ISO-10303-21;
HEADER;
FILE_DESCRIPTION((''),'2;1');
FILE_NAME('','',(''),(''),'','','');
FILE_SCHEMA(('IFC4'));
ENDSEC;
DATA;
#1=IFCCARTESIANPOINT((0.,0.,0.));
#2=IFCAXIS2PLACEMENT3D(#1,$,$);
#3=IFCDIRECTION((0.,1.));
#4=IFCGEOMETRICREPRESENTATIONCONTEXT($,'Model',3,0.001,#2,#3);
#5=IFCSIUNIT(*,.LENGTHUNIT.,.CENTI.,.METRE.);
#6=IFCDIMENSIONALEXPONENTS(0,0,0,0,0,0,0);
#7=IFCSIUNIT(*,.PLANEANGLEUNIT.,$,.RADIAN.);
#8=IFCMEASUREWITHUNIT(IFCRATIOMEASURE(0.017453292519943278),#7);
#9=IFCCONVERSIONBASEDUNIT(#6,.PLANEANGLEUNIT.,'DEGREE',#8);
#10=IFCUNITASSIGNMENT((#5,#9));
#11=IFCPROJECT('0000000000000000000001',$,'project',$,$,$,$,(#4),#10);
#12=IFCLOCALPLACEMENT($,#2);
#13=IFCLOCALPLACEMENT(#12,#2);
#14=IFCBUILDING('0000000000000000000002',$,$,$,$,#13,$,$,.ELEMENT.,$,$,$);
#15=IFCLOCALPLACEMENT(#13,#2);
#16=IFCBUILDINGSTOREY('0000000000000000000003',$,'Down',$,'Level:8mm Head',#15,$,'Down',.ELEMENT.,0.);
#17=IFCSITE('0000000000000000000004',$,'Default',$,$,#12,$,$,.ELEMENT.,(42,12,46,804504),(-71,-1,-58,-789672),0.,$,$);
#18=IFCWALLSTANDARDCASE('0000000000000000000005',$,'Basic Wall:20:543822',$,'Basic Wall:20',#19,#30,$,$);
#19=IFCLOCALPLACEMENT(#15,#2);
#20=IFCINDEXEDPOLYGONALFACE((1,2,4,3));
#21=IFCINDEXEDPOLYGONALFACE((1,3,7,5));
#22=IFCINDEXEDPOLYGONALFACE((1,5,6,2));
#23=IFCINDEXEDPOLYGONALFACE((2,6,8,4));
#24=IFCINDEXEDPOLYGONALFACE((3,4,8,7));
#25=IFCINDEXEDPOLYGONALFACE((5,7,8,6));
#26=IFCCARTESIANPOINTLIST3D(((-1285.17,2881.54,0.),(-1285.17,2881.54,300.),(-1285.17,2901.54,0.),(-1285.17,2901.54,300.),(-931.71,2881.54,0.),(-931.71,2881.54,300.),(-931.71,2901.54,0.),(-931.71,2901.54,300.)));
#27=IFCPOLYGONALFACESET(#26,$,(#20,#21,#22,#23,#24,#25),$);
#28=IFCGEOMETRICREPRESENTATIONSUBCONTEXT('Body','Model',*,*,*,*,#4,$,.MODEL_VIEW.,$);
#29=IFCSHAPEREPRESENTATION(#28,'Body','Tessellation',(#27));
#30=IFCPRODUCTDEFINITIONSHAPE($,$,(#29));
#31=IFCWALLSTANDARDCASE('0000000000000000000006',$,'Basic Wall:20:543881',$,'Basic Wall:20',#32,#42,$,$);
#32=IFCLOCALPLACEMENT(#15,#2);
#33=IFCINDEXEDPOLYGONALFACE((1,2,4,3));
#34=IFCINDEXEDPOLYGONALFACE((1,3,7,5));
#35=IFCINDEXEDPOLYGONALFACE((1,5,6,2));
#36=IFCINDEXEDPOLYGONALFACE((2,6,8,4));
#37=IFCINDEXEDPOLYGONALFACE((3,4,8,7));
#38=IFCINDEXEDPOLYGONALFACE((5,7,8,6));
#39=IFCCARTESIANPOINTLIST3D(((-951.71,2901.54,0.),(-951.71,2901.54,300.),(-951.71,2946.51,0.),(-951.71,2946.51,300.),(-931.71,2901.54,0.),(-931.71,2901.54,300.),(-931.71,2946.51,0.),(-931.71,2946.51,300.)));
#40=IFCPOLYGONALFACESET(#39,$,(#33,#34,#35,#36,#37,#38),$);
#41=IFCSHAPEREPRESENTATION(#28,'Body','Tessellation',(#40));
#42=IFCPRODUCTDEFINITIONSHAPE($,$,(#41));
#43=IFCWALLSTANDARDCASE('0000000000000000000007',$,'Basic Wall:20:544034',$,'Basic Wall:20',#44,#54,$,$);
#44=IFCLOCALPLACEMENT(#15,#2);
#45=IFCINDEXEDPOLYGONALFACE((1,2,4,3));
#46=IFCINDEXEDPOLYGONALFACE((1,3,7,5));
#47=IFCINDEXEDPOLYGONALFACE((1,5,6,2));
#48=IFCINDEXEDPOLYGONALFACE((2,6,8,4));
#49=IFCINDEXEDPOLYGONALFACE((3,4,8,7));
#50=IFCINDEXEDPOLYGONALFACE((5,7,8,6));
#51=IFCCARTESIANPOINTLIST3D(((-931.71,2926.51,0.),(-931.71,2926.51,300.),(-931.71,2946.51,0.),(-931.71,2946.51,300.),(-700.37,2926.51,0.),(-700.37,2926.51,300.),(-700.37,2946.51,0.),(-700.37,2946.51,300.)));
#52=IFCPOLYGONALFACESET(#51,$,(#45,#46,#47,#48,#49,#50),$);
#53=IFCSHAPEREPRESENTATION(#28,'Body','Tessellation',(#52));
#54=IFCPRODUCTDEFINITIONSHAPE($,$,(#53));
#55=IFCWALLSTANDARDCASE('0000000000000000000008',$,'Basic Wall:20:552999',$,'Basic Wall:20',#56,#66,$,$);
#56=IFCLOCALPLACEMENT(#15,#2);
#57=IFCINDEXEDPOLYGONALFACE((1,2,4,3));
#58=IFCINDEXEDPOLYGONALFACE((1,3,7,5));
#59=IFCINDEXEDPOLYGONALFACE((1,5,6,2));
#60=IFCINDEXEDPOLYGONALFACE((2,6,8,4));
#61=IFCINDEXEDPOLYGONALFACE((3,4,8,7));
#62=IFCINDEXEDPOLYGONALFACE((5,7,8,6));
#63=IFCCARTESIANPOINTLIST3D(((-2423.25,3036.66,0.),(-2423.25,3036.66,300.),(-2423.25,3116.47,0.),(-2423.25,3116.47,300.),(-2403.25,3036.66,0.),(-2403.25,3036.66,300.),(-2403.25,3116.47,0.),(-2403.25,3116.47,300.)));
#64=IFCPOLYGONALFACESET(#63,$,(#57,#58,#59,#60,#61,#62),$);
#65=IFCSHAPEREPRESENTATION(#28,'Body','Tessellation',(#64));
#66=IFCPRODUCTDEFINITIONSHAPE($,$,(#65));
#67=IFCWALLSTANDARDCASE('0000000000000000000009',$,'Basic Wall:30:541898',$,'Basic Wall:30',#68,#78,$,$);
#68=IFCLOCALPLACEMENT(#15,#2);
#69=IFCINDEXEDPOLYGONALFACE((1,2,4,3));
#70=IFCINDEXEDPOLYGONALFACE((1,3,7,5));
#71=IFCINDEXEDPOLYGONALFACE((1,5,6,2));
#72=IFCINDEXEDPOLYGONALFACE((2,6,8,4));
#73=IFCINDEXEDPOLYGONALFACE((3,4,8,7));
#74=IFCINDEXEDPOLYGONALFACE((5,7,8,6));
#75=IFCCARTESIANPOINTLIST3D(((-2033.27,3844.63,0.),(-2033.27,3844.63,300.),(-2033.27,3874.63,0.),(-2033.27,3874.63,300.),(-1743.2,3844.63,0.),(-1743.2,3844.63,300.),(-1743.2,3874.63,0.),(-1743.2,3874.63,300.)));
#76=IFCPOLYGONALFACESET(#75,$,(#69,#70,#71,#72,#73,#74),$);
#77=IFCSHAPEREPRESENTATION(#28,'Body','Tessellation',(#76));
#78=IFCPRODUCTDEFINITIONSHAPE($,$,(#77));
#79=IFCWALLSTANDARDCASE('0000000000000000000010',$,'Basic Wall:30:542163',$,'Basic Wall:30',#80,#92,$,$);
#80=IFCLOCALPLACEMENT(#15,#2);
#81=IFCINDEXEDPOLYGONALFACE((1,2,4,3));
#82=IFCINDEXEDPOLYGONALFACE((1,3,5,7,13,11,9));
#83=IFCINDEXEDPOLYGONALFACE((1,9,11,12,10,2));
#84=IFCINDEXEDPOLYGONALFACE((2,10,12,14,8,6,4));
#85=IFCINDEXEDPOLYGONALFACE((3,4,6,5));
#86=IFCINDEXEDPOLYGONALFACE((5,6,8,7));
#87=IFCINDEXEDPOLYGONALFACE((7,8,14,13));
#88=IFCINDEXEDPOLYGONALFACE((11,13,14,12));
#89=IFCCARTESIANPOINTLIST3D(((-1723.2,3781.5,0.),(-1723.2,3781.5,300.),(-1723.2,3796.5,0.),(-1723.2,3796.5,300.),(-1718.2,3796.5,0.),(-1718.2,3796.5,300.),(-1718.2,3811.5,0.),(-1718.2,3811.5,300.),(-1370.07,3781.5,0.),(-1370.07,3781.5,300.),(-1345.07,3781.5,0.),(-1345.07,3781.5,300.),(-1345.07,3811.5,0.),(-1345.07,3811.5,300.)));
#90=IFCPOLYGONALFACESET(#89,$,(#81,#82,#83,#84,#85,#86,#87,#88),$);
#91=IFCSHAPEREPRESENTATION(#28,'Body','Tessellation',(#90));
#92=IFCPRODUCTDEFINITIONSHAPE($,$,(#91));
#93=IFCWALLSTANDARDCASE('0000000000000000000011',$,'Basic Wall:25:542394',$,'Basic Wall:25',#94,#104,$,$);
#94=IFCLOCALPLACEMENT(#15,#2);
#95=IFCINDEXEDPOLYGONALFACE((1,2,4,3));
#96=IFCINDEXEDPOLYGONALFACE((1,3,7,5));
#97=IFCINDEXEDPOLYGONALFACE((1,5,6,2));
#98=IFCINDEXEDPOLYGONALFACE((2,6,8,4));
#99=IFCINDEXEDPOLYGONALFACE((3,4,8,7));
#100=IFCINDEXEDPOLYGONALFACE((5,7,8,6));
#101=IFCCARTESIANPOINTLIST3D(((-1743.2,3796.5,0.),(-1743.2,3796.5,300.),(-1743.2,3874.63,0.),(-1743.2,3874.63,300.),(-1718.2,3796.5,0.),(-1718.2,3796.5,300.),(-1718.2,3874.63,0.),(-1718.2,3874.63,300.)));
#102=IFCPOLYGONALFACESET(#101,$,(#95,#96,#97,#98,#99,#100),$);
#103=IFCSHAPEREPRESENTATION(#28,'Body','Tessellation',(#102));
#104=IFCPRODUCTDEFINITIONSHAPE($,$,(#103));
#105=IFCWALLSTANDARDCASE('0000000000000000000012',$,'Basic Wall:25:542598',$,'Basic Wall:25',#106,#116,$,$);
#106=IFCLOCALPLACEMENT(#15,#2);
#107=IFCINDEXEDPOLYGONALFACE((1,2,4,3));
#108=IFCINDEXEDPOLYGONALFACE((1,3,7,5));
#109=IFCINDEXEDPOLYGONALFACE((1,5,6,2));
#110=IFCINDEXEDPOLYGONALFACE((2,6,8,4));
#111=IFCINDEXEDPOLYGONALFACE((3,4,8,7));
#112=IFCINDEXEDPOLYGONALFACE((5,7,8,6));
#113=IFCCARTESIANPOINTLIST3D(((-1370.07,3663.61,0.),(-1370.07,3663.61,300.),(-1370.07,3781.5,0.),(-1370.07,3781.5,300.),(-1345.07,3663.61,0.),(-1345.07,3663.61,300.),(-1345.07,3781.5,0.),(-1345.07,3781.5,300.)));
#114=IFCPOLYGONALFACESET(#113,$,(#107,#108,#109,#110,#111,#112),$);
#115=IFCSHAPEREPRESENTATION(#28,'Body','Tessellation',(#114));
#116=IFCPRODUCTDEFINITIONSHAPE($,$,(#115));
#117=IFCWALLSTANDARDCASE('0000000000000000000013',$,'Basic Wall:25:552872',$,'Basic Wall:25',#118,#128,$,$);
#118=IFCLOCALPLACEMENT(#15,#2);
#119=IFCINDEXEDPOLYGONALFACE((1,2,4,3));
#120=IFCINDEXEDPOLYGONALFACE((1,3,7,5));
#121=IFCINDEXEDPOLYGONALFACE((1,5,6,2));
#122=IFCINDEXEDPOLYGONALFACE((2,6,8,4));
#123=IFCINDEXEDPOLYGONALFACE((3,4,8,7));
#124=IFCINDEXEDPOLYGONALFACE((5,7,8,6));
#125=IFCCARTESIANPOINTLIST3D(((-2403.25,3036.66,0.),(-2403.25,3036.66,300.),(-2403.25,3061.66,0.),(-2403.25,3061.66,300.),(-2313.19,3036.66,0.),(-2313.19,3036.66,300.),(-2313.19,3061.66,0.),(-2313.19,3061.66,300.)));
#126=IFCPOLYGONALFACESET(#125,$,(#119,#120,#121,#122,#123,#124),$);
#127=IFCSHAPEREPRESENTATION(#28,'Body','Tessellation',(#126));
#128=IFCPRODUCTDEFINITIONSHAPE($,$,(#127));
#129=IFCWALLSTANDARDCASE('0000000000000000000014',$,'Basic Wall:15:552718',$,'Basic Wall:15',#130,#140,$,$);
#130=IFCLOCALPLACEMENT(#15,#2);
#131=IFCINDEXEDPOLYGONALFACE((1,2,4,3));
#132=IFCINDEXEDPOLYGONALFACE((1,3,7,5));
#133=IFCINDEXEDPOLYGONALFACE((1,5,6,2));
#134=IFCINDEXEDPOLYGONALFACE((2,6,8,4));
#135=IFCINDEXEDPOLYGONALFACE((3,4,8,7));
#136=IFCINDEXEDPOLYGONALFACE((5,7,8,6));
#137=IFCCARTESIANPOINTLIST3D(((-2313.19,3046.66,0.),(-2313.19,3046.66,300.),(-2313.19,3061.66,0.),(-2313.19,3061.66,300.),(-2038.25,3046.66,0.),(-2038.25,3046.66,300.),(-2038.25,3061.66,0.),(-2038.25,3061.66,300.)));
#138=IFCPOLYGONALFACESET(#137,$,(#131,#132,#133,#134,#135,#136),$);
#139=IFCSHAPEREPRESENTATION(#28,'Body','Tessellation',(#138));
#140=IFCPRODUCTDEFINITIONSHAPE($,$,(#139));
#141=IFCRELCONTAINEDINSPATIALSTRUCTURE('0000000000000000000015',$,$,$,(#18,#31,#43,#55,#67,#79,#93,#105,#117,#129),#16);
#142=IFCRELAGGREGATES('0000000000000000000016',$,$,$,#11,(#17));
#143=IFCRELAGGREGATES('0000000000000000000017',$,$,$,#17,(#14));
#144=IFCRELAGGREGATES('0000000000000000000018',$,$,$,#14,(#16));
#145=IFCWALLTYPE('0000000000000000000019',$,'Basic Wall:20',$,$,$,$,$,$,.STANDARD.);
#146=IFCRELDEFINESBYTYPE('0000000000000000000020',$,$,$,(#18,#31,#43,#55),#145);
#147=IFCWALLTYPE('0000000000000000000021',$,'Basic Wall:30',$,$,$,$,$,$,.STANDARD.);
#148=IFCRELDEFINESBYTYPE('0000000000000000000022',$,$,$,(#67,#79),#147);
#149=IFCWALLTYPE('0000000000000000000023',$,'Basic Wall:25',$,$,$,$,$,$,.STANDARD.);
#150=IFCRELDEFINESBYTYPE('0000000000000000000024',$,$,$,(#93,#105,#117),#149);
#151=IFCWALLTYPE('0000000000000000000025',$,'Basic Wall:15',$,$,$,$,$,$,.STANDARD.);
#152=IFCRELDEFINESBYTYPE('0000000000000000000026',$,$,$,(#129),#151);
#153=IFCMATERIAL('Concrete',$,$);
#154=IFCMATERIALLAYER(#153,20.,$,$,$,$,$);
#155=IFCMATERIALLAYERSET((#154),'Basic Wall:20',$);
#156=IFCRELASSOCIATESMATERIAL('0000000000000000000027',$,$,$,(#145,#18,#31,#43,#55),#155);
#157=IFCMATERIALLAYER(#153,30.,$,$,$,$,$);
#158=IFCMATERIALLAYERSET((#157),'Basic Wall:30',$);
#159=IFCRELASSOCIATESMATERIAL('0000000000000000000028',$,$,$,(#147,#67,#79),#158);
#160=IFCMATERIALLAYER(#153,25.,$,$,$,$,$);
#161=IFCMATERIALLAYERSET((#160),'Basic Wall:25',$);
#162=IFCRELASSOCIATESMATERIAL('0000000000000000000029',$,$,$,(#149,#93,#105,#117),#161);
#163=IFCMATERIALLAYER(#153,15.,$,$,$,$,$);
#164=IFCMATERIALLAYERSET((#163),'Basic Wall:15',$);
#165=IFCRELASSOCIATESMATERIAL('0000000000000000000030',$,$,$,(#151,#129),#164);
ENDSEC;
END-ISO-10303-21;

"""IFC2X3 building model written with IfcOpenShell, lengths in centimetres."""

from ifc_helpers import new_model, entity, si_unit, converted_unit, direction, frame, frame_2d, origin, place, context, subcontext, project, spatial, polyline, rectangle, outline, extrude, material, layer, layer_set, layer_usage, type_object, element, save


model = new_model("IFC2X3")

# Units and contexts
model_context = context("Model", 3, precision=0.001, world=origin(), true_north=direction((0.0, 1.0)))
body_context = subcontext(model_context, "Body", "Model", "MODEL_VIEW")
ifc_project = project(units=[si_unit("LENGTHUNIT", "METRE", prefix="CENTI"), converted_unit("PLANEANGLEUNIT", "DEGREE", entity("IfcRatioMeasure", 0.017453292519943278), si_unit("PLANEANGLEUNIT", "RADIAN"), dimensions=[0, 0, 0, 0, 0, 0, 0])], contexts=[model_context])

# Site, building, storey
site_placement = place(None, origin())
site = spatial("IfcSite", under=ifc_project, at=site_placement, Name="Default", CompositionType="ELEMENT", RefLatitude=(42, 12, 46, 804504), RefLongitude=(-71, -1, -58, -789672), RefElevation=0.0)
building_placement = place(site_placement, origin())
building = spatial("IfcBuilding", under=site, at=building_placement, CompositionType="ELEMENT")
storey_placement = place(building_placement, origin())
storey = spatial("IfcBuildingStorey", under=building, at=storey_placement, Name="Down", ObjectType="Level:8mm Head", LongName="Down", CompositionType="ELEMENT", Elevation=0.0)

# Walls
ifc_material = material(Name="Concrete")
ifc_layer_1 = layer(ifc_material, 20.0)
ifc_layer_set_1 = layer_set([ifc_layer_1], Name="Basic Wall:20")
wall_type_1 = type_object("IfcWallType", Name="Basic Wall:20", PredefinedType="STANDARD", material=ifc_layer_set_1)
ifc_layer_usage_1 = layer_usage(ifc_layer_set_1, "AXIS2", "POSITIVE", -10.0)
wall_1_placement = place(storey_placement, frame((-1285.17, 2891.54, 0.0)))
element("IfcWallStandardCase", 1, at=wall_1_placement, inside=storey, type_object=wall_type_1, material=ifc_layer_usage_1, Name="Basic Wall:20:543822", ObjectType="Basic Wall:20", context=body_context, shape_type="SweptSolid", body=[
    extrude(rectangle(XDim=353.47, YDim=20.0, at=frame_2d((176.73, 0.0), x_axis=(-1.0, 0.0))), origin(), (0.0, 0.0, 1.0), 300.0),
])
ifc_layer_usage_2 = layer_usage(ifc_layer_set_1, "AXIS2", "POSITIVE", -10.0)
wall_2_placement = place(storey_placement, frame((-941.71, 2901.54, 0.0), z_axis=(0.0, 0.0, 1.0), x_axis=(0.0, 1.0, 0.0)))
element("IfcWallStandardCase", 2, at=wall_2_placement, inside=storey, type_object=wall_type_1, material=ifc_layer_usage_2, Name="Basic Wall:20:543881", ObjectType="Basic Wall:20", context=body_context, shape_type="SweptSolid", body=[
    extrude(rectangle(XDim=44.98, YDim=20.0, at=frame_2d((22.49, 0.0), x_axis=(-1.0, 0.0))), origin(), (0.0, 0.0, 1.0), 300.0),
])
ifc_layer_usage_3 = layer_usage(ifc_layer_set_1, "AXIS2", "NEGATIVE", 10.0)
wall_3_placement = place(storey_placement, frame((-931.71, 2936.51, 0.0)))
element("IfcWallStandardCase", 3, at=wall_3_placement, inside=storey, type_object=wall_type_1, material=ifc_layer_usage_3, Name="Basic Wall:20:544034", ObjectType="Basic Wall:20", context=body_context, shape_type="SweptSolid", body=[
    extrude(rectangle(XDim=231.34, YDim=20.0, at=frame_2d((115.67, 0.0), x_axis=(-1.0, 0.0))), origin(), (0.0, 0.0, 1.0), 300.0),
])
ifc_layer_usage_4 = layer_usage(ifc_layer_set_1, "AXIS2", "NEGATIVE", 10.0)
wall_4_placement = place(storey_placement, frame((-2413.25, 3036.66, 0.0), z_axis=(0.0, 0.0, 1.0), x_axis=(0.0, 1.0, 0.0)))
element("IfcWallStandardCase", 4, at=wall_4_placement, inside=storey, type_object=wall_type_1, material=ifc_layer_usage_4, Name="Basic Wall:20:552999", ObjectType="Basic Wall:20", context=body_context, shape_type="SweptSolid", body=[
    extrude(rectangle(XDim=79.82, YDim=20.0, at=frame_2d((39.91, 0.0), x_axis=(-1.0, 0.0))), origin(), (0.0, 0.0, 1.0), 300.0),
])
ifc_layer_2 = layer(ifc_material, 30.0)
ifc_layer_set_2 = layer_set([ifc_layer_2], Name="Basic Wall:30")
ifc_layer_usage_5 = layer_usage(ifc_layer_set_2, "AXIS2", "NEGATIVE", 15.0)
wall_type_2 = type_object("IfcWallType", Name="Basic Wall:30", PredefinedType="STANDARD", material=ifc_layer_set_2)
wall_5_placement = place(storey_placement, frame((-2033.27, 3859.63, 0.0)))
element("IfcWallStandardCase", 5, at=wall_5_placement, inside=storey, type_object=wall_type_2, material=ifc_layer_usage_5, Name="Basic Wall:30:541898", ObjectType="Basic Wall:30", context=body_context, shape_type="SweptSolid", body=[
    extrude(rectangle(XDim=290.07, YDim=30.0, at=frame_2d((145.04, 0.0), x_axis=(-1.0, 0.0))), origin(), (0.0, 0.0, 1.0), 300.0),
])
ifc_layer_usage_6 = layer_usage(ifc_layer_set_2, "AXIS2", "POSITIVE", -15.0)
wall_6_placement = place(storey_placement, frame((-1723.2, 3796.5, 0.0)))
element("IfcWallStandardCase", 6, at=wall_6_placement, inside=storey, type_object=wall_type_2, material=ifc_layer_usage_6, Name="Basic Wall:30:542163", ObjectType="Basic Wall:30", context=body_context, shape_type="SweptSolid", body=[
    extrude(outline(polyline([(378.13, -15.0), (378.13, 15.0), (5.0, 15.0), (5.0, 0.0), (0.0, 0.0), (0.0, -15.0), (353.13, -15.0), (378.13, -15.0)])), origin(), (0.0, 0.0, 1.0), 300.0),
])
ifc_layer_3 = layer(ifc_material, 25.0)
ifc_layer_set_3 = layer_set([ifc_layer_3], Name="Basic Wall:25")
ifc_layer_usage_7 = layer_usage(ifc_layer_set_3, "AXIS2", "NEGATIVE", 12.5)
wall_type_3 = type_object("IfcWallType", Name="Basic Wall:25", PredefinedType="STANDARD", material=ifc_layer_set_3)
wall_7_placement = place(storey_placement, frame((-1730.7, 3874.63, 0.0), z_axis=(0.0, 0.0, 1.0), x_axis=(0.0, -1.0, 0.0)))
element("IfcWallStandardCase", 7, at=wall_7_placement, inside=storey, type_object=wall_type_3, material=ifc_layer_usage_7, Name="Basic Wall:25:542394", ObjectType="Basic Wall:25", context=body_context, shape_type="SweptSolid", body=[
    extrude(rectangle(XDim=78.13, YDim=25.0, at=frame_2d((39.06, 0.0), x_axis=(-1.0, 0.0))), origin(), (0.0, 0.0, 1.0), 300.0),
])
ifc_layer_usage_8 = layer_usage(ifc_layer_set_3, "AXIS2", "NEGATIVE", 12.5)
wall_8_placement = place(storey_placement, frame((-1357.57, 3781.5, 0.0), z_axis=(0.0, 0.0, 1.0), x_axis=(0.0, -1.0, 0.0)))
element("IfcWallStandardCase", 8, at=wall_8_placement, inside=storey, type_object=wall_type_3, material=ifc_layer_usage_8, Name="Basic Wall:25:542598", ObjectType="Basic Wall:25", context=body_context, shape_type="SweptSolid", body=[
    extrude(rectangle(XDim=117.89, YDim=25.0, at=frame_2d((58.95, 0.0), x_axis=(-1.0, 0.0))), origin(), (0.0, 0.0, 1.0), 300.0),
])
ifc_layer_usage_9 = layer_usage(ifc_layer_set_3, "AXIS2", "POSITIVE", -12.5)
wall_9_placement = place(storey_placement, frame((-2313.19, 3049.16, 0.0), z_axis=(0.0, 0.0, 1.0), x_axis=(-1.0, 0.0, 0.0)))
element("IfcWallStandardCase", 9, at=wall_9_placement, inside=storey, type_object=wall_type_3, material=ifc_layer_usage_9, Name="Basic Wall:25:552872", ObjectType="Basic Wall:25", context=body_context, shape_type="SweptSolid", body=[
    extrude(rectangle(XDim=90.06, YDim=25.0, at=frame_2d((45.03, 0.0), x_axis=(-1.0, 0.0))), origin(), (0.0, 0.0, 1.0), 300.0),
])
ifc_layer_4 = layer(ifc_material, 15.0)
ifc_layer_set_4 = layer_set([ifc_layer_4], Name="Basic Wall:15")
ifc_layer_usage_10 = layer_usage(ifc_layer_set_4, "AXIS2", "POSITIVE", -7.5)
wall_type_4 = type_object("IfcWallType", Name="Basic Wall:15", PredefinedType="STANDARD", material=ifc_layer_set_4)
wall_10_placement = place(storey_placement, frame((-2038.25, 3054.16, 0.0), z_axis=(0.0, 0.0, 1.0), x_axis=(-1.0, 0.0, 0.0)))
element("IfcWallStandardCase", 10, at=wall_10_placement, inside=storey, type_object=wall_type_4, material=ifc_layer_usage_10, Name="Basic Wall:15:552718", ObjectType="Basic Wall:15", context=body_context, shape_type="SweptSolid", body=[
    extrude(rectangle(XDim=274.94, YDim=15.0, at=frame_2d((137.47, 0.0), x_axis=(-1.0, 0.0))), origin(), (0.0, 0.0, 1.0), 300.0),
])

save(model, "model.ifc")
